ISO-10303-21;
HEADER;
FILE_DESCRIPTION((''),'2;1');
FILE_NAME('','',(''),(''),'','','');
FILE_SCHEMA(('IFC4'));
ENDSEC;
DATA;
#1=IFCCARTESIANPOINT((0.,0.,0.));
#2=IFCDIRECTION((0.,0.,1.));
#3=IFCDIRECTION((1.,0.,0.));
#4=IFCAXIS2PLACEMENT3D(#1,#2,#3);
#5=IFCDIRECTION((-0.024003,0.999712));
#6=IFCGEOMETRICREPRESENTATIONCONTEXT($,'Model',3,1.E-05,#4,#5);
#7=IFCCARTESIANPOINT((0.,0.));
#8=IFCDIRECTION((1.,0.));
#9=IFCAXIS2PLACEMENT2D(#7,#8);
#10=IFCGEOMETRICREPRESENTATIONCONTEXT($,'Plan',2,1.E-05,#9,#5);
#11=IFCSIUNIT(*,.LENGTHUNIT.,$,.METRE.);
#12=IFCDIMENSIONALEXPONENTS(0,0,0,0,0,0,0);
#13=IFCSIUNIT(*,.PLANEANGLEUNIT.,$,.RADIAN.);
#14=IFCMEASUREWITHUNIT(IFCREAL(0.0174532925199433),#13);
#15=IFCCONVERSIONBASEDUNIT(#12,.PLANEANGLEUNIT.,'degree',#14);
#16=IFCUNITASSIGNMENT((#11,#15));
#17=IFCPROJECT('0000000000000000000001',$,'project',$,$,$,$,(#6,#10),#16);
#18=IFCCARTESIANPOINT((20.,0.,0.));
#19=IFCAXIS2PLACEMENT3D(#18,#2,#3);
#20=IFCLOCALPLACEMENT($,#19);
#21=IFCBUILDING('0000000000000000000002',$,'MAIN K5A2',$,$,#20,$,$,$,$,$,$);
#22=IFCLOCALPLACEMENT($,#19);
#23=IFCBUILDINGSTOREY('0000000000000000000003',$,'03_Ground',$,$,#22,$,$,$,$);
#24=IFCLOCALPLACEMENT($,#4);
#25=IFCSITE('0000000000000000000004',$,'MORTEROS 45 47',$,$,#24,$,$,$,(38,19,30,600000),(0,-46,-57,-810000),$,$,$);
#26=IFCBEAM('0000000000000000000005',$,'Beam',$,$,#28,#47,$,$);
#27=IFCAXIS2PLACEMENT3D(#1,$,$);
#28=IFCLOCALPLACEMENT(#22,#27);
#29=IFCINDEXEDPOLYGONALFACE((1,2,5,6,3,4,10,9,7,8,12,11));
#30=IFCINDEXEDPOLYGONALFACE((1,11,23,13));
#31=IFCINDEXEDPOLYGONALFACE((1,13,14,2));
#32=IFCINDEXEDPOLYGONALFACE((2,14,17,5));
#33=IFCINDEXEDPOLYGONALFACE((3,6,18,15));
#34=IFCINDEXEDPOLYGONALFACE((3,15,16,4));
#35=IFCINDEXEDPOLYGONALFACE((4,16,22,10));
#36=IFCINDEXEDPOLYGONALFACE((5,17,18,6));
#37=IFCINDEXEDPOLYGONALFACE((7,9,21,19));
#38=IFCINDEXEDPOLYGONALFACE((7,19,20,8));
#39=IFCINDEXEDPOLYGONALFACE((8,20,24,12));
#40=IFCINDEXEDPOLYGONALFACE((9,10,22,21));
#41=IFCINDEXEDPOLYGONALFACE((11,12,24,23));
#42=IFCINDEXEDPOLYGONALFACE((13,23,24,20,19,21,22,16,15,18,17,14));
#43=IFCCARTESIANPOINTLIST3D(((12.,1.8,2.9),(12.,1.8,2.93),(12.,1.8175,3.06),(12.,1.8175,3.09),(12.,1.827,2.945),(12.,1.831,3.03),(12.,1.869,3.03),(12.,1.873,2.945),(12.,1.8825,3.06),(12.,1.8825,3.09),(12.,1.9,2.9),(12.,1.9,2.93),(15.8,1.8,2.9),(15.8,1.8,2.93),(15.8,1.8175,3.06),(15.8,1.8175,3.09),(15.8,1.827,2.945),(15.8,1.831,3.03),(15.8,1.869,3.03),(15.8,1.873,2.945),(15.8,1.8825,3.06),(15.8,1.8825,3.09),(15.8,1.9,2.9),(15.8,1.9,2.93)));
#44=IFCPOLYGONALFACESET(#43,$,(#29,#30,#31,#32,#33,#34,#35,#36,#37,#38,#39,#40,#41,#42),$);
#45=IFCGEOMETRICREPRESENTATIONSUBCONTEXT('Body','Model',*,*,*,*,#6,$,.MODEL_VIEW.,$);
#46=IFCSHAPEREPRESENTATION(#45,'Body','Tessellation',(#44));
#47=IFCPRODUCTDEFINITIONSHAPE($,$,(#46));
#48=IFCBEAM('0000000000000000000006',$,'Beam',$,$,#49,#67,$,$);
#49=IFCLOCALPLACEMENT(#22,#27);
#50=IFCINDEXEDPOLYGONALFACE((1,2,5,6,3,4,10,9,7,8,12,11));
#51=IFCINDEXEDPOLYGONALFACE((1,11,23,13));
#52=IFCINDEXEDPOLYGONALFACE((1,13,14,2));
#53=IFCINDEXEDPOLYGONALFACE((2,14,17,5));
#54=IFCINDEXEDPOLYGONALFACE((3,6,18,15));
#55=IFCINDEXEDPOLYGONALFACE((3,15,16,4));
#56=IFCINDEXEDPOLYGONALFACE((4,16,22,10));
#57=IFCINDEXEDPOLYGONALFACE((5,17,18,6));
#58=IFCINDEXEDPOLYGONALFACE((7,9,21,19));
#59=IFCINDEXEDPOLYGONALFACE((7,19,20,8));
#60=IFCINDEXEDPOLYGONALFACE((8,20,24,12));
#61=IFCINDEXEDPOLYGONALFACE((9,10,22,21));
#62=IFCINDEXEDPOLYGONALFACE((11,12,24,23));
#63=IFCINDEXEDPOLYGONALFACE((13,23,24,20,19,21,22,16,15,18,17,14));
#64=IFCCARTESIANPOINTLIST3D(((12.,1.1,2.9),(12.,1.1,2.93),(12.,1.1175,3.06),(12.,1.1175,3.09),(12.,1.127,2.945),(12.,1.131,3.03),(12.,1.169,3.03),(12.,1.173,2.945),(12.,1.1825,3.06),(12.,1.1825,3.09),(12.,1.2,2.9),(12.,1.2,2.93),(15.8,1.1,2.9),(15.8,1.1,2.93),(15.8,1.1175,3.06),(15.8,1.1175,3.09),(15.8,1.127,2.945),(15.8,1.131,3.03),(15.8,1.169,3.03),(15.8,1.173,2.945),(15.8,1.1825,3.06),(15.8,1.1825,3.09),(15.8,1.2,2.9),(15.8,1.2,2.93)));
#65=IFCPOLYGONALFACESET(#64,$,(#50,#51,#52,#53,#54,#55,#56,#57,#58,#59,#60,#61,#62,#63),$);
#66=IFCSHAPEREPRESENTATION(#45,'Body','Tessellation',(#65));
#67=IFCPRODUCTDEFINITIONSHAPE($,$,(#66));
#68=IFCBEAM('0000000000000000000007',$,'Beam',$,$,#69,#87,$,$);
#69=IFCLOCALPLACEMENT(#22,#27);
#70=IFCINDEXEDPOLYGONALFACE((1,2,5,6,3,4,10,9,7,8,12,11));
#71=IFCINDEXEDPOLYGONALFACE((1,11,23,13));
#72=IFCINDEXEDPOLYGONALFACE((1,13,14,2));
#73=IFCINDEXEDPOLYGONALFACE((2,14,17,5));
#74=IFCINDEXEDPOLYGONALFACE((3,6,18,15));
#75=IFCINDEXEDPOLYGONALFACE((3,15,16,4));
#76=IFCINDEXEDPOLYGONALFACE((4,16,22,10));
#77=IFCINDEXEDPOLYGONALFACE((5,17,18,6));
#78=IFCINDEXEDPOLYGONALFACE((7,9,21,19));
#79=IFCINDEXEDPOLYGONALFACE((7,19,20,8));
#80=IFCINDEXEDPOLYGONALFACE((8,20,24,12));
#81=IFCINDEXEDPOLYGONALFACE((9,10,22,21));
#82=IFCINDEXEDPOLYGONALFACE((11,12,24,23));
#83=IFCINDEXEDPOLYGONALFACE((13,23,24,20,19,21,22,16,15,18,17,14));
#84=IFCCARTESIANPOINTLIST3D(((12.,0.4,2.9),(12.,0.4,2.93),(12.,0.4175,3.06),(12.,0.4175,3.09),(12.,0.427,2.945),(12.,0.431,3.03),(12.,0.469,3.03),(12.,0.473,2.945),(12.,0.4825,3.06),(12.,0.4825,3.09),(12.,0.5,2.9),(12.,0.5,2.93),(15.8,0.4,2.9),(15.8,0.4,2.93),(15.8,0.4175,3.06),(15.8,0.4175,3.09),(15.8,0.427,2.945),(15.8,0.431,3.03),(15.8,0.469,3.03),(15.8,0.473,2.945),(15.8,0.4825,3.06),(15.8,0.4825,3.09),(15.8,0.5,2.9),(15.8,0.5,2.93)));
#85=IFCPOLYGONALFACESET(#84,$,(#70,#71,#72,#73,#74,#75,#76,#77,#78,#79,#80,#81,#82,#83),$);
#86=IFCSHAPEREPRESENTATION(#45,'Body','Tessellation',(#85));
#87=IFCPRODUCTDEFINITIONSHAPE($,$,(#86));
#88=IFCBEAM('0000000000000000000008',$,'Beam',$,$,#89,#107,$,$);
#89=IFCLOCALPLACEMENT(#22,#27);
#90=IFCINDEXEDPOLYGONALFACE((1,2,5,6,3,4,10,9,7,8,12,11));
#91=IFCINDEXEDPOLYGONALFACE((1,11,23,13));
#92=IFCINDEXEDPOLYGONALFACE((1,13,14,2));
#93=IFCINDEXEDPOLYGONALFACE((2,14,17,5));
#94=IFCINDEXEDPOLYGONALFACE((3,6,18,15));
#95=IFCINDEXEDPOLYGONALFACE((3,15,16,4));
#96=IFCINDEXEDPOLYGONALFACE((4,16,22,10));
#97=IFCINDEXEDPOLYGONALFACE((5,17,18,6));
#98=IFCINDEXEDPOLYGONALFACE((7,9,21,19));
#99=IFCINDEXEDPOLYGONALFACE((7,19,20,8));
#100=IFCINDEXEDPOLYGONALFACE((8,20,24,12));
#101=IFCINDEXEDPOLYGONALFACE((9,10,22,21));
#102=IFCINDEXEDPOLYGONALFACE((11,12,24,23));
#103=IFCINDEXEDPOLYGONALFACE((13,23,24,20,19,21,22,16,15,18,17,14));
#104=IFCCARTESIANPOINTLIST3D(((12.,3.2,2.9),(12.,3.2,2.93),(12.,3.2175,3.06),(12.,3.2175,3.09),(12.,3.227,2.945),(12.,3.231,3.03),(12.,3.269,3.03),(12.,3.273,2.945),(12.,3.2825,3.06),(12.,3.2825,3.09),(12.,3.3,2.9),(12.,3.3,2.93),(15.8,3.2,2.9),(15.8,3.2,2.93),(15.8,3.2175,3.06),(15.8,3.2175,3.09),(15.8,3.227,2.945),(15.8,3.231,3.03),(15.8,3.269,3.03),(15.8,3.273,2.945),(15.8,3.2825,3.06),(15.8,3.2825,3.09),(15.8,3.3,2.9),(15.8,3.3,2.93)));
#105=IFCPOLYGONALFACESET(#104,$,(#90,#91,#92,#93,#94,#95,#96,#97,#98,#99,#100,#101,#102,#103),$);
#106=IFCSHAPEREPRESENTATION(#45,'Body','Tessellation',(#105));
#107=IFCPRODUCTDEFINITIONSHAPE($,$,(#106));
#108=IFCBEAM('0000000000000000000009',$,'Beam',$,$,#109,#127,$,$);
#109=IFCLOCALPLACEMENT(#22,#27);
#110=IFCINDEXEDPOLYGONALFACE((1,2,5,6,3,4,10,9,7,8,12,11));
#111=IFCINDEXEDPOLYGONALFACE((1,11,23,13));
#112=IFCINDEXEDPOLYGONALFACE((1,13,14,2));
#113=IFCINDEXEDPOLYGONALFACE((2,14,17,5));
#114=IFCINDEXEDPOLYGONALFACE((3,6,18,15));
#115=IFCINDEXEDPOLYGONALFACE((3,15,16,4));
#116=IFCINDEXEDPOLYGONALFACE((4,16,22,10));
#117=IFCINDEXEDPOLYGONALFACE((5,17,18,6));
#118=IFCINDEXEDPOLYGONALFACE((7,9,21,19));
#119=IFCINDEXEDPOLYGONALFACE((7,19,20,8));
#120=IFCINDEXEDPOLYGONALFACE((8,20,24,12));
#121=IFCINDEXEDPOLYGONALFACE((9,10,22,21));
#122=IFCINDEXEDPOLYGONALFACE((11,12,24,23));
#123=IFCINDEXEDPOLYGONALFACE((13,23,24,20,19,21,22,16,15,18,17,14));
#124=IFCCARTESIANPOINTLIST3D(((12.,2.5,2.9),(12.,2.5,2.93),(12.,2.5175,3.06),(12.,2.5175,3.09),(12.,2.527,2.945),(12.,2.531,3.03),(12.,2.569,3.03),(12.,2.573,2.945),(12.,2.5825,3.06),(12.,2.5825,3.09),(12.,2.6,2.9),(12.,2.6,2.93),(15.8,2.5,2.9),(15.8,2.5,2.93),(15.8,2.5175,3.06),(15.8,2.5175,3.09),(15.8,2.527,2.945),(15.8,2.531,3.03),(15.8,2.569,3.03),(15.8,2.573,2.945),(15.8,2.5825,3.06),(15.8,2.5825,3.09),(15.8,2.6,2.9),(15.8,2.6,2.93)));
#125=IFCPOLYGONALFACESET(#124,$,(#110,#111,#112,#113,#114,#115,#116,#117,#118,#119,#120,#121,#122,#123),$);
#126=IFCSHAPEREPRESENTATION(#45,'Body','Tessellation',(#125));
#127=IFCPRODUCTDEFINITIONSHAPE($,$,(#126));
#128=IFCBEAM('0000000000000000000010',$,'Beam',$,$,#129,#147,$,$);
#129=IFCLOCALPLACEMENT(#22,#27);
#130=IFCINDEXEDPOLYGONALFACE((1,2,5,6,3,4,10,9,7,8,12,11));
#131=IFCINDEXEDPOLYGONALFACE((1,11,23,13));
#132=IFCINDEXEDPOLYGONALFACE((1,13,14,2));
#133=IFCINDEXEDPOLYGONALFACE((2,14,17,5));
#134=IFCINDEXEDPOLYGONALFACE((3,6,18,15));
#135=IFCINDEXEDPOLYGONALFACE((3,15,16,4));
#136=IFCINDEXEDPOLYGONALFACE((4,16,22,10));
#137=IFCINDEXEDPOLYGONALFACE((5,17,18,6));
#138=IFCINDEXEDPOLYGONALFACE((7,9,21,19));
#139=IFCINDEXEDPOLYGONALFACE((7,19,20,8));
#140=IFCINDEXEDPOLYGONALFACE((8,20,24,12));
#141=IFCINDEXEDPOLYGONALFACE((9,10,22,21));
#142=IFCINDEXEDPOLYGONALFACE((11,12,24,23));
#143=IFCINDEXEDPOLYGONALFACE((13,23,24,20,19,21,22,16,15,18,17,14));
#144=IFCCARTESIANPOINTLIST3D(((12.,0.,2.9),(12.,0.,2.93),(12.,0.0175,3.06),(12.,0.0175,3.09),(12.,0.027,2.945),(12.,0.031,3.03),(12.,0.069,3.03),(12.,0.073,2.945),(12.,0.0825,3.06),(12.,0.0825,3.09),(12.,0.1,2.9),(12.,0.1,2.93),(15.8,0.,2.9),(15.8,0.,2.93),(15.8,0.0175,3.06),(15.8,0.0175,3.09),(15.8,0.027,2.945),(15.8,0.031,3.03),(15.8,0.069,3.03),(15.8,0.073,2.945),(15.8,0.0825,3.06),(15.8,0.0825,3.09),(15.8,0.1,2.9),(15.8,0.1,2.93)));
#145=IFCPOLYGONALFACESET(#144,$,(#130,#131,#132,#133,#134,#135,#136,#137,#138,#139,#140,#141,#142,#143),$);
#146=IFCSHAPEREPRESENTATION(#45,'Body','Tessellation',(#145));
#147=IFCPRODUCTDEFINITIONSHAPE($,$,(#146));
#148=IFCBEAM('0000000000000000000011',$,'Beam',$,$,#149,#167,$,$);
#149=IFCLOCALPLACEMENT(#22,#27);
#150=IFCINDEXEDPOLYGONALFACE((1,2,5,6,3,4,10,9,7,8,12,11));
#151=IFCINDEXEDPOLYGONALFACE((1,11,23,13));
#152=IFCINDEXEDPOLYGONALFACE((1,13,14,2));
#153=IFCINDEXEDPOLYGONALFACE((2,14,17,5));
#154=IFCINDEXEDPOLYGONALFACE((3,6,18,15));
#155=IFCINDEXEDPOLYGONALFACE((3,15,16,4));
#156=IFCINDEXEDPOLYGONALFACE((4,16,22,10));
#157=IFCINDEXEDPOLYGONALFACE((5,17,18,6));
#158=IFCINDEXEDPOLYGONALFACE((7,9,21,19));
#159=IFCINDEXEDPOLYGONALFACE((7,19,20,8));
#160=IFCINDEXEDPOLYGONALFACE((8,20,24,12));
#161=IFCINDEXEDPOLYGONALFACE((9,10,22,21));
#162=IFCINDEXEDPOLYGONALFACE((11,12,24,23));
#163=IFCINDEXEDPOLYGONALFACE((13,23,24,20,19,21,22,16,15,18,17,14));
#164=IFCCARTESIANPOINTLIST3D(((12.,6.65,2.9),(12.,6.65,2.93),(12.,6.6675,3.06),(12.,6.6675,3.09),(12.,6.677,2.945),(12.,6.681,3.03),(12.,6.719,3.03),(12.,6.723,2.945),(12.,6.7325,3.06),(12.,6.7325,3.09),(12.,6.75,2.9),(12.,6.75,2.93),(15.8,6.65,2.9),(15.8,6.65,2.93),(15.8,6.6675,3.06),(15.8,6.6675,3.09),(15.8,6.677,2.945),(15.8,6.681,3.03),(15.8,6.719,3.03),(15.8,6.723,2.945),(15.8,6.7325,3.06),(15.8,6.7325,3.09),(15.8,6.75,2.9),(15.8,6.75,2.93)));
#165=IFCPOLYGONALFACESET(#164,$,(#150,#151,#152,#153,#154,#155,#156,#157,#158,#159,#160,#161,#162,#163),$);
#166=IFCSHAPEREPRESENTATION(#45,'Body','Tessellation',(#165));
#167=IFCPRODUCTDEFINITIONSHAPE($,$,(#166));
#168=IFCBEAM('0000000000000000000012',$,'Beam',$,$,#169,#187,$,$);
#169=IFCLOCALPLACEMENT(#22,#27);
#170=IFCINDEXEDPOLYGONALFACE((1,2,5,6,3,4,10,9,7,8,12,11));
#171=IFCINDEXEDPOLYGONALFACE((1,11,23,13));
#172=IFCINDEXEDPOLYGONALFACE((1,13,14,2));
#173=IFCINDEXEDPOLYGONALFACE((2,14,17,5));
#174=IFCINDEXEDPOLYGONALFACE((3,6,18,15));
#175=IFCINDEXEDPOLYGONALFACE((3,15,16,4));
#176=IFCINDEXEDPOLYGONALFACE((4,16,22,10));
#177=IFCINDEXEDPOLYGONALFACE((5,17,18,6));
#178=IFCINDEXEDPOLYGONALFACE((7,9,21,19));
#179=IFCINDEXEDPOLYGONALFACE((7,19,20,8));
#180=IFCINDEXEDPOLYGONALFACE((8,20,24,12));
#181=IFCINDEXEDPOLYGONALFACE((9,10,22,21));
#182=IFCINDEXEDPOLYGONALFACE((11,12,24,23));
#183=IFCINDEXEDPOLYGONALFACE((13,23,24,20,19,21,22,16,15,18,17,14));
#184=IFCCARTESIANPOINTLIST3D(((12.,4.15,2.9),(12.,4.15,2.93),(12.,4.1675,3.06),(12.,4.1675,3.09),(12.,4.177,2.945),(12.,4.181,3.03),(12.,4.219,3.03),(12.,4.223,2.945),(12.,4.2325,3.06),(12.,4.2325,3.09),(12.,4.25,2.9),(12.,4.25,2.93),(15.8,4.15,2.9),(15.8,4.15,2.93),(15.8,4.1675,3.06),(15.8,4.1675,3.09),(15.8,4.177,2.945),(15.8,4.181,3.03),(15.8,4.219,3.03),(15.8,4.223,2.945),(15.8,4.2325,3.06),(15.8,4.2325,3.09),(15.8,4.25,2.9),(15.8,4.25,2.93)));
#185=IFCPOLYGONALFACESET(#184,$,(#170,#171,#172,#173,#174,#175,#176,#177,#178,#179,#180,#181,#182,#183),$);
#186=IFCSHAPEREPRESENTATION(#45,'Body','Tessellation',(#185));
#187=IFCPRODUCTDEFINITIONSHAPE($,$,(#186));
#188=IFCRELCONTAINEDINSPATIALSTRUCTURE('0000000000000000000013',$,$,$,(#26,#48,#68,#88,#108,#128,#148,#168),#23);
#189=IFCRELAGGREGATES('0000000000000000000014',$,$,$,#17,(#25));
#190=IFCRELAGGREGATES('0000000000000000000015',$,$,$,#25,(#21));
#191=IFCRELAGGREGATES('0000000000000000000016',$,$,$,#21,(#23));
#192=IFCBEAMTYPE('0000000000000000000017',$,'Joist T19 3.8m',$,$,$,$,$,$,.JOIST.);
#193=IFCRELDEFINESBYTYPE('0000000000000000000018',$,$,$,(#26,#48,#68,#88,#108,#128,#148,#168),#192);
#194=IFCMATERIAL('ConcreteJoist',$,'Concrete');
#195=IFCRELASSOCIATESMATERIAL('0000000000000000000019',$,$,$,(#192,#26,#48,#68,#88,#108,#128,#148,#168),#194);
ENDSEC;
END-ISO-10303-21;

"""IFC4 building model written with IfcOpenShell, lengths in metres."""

from ifc_helpers import new_model, entity, si_unit, converted_unit, direction, frame, origin_with_axes, origin_2d_with_axis, place, context, subcontext, project, spatial, indexed_curve, outline, extrude, material, material_profile, profile_set, profile_usage, type_object, element, save


model = new_model("IFC4")

# Units and contexts
model_context = context("Model", 3, precision=1e-05, world=origin_with_axes(), true_north=direction((-0.024003, 0.999712)))
plan_context = context("Plan", 2, precision=1e-05, world=origin_2d_with_axis(), true_north=direction((-0.024003, 0.999712)))
body_context_1 = subcontext(model_context, "Body", "Model", "MODEL_VIEW")
ifc_project = project(units=[si_unit("LENGTHUNIT", "METRE"), converted_unit("PLANEANGLEUNIT", "degree", entity("IfcReal", 0.0174532925199433), si_unit("PLANEANGLEUNIT", "RADIAN"), dimensions=[0, 0, 0, 0, 0, 0, 0])], contexts=[model_context, plan_context])

# Site, building, storey
site_placement = place(None, origin_with_axes())
site = spatial("IfcSite", under=ifc_project, at=site_placement, Name="MORTEROS 45 47", RefLatitude=(38, 19, 30, 600000), RefLongitude=(0, -46, -57, -810000))
building_placement = place(None, frame((20.0, 0.0, 0.0), z_axis=(0.0, 0.0, 1.0), x_axis=(1.0, 0.0, 0.0)))
building = spatial("IfcBuilding", under=site, at=building_placement, Name="MAIN K5A2")
storey_placement = place(None, frame((20.0, 0.0, 0.0), z_axis=(0.0, 0.0, 1.0), x_axis=(1.0, 0.0, 0.0)))
storey = spatial("IfcBuildingStorey", under=building, at=storey_placement, Name="03_Ground")

# Beams
ifc_material = material(Name="ConcreteJoist", Category="Concrete")
ifc_material_profile_1 = material_profile(ifc_material, outline(indexed_curve([(0.019, 0.13), (0.023, 0.045), (0.05, 0.03), (0.05, 0.0), (-0.05, 0.0), (-0.05, 0.03), (-0.023, 0.045), (-0.019, 0.13), (-0.0325, 0.16), (-0.0325, 0.19), (0.0325, 0.19), (0.0325, 0.16), (0.019, 0.13)])))
ifc_profile_set_1 = profile_set([ifc_material_profile_1], Name="JoistMaterialProfileSet")
ifc_material_profile_2 = material_profile(ifc_material, outline(indexed_curve([(0.019, 0.13), (0.023, 0.045), (0.05, 0.03), (0.05, 0.0), (-0.05, 0.0), (-0.05, 0.03), (-0.023, 0.045), (-0.019, 0.13), (-0.0325, 0.16), (-0.0325, 0.19), (0.0325, 0.19), (0.0325, 0.16), (0.019, 0.13)])))
ifc_profile_set_2 = profile_set([ifc_material_profile_2], Name="JoistMaterialProfileSet")
beam_type_1 = type_object("IfcBeamType", Name="Joist T19 3.8m", PredefinedType="JOIST", material=ifc_profile_set_2)
ifc_profile_usage_1 = profile_usage(ifc_profile_set_1)
beam_1_placement = place(None, frame((32.0, 1.85, 2.9), z_axis=(1.0, 0.0, 0.0), x_axis=(0.0, 1.0, 0.0)))
element("IfcBeam", 1, at=beam_1_placement, inside=storey, type_object=beam_type_1, material=ifc_profile_usage_1, Name="Beam", context=body_context_1, shape_type="SweptSolid", body=[
    extrude(outline(indexed_curve([(0.019, 0.13), (0.023, 0.045), (0.05, 0.03), (0.05, 0.0), (-0.05, 0.0), (-0.05, 0.03), (-0.023, 0.045), (-0.019, 0.13), (-0.0325, 0.16), (-0.0325, 0.19), (0.0325, 0.19), (0.0325, 0.16), (0.019, 0.13)])), origin_with_axes(), (0.0, 0.0, 1.0), 3.8),
])
ifc_profile_usage_2 = profile_usage(ifc_profile_set_1)
beam_2_placement = place(None, frame((32.0, 1.15, 2.9), z_axis=(1.0, 0.0, 0.0), x_axis=(0.0, 1.0, 0.0)))
element("IfcBeam", 2, at=beam_2_placement, inside=storey, type_object=beam_type_1, material=ifc_profile_usage_2, Name="Beam", context=body_context_1, shape_type="SweptSolid", body=[
    extrude(outline(indexed_curve([(0.019, 0.13), (0.023, 0.045), (0.05, 0.03), (0.05, 0.0), (-0.05, 0.0), (-0.05, 0.03), (-0.023, 0.045), (-0.019, 0.13), (-0.0325, 0.16), (-0.0325, 0.19), (0.0325, 0.19), (0.0325, 0.16), (0.019, 0.13)])), origin_with_axes(), (0.0, 0.0, 1.0), 3.8),
])
ifc_profile_usage_3 = profile_usage(ifc_profile_set_1)
beam_3_placement = place(None, frame((32.0, 0.45, 2.9), z_axis=(1.0, 0.0, 0.0), x_axis=(0.0, 1.0, 0.0)))
element("IfcBeam", 3, at=beam_3_placement, inside=storey, type_object=beam_type_1, material=ifc_profile_usage_3, Name="Beam", context=body_context_1, shape_type="SweptSolid", body=[
    extrude(outline(indexed_curve([(0.019, 0.13), (0.023, 0.045), (0.05, 0.03), (0.05, 0.0), (-0.05, 0.0), (-0.05, 0.03), (-0.023, 0.045), (-0.019, 0.13), (-0.0325, 0.16), (-0.0325, 0.19), (0.0325, 0.19), (0.0325, 0.16), (0.019, 0.13)])), origin_with_axes(), (0.0, 0.0, 1.0), 3.8),
])
ifc_profile_usage_4 = profile_usage(ifc_profile_set_1)
beam_4_placement = place(None, frame((32.0, 3.25, 2.9), z_axis=(1.0, 0.0, 0.0), x_axis=(0.0, 1.0, 0.0)))
element("IfcBeam", 4, at=beam_4_placement, inside=storey, type_object=beam_type_1, material=ifc_profile_usage_4, Name="Beam", context=body_context_1, shape_type="SweptSolid", body=[
    extrude(outline(indexed_curve([(0.019, 0.13), (0.023, 0.045), (0.05, 0.03), (0.05, 0.0), (-0.05, 0.0), (-0.05, 0.03), (-0.023, 0.045), (-0.019, 0.13), (-0.0325, 0.16), (-0.0325, 0.19), (0.0325, 0.19), (0.0325, 0.16), (0.019, 0.13)])), origin_with_axes(), (0.0, 0.0, 1.0), 3.8),
])
ifc_profile_usage_5 = profile_usage(ifc_profile_set_1)
beam_5_placement = place(None, frame((32.0, 2.55, 2.9), z_axis=(1.0, 0.0, 0.0), x_axis=(0.0, 1.0, 0.0)))
element("IfcBeam", 5, at=beam_5_placement, inside=storey, type_object=beam_type_1, material=ifc_profile_usage_5, Name="Beam", context=body_context_1, shape_type="SweptSolid", body=[
    extrude(outline(indexed_curve([(0.019, 0.13), (0.023, 0.045), (0.05, 0.03), (0.05, 0.0), (-0.05, 0.0), (-0.05, 0.03), (-0.023, 0.045), (-0.019, 0.13), (-0.0325, 0.16), (-0.0325, 0.19), (0.0325, 0.19), (0.0325, 0.16), (0.019, 0.13)])), origin_with_axes(), (0.0, 0.0, 1.0), 3.8),
])
ifc_profile_usage_6 = profile_usage(ifc_profile_set_1)
beam_6_placement = place(None, frame((32.0, 0.05, 2.9), z_axis=(1.0, 0.0, 0.0), x_axis=(0.0, 1.0, 0.0)))
element("IfcBeam", 6, at=beam_6_placement, inside=storey, type_object=beam_type_1, material=ifc_profile_usage_6, Name="Beam", context=body_context_1, shape_type="SweptSolid", body=[
    extrude(outline(indexed_curve([(0.019, 0.13), (0.023, 0.045), (0.05, 0.03), (0.05, 0.0), (-0.05, 0.0), (-0.05, 0.03), (-0.023, 0.045), (-0.019, 0.13), (-0.0325, 0.16), (-0.0325, 0.19), (0.0325, 0.19), (0.0325, 0.16), (0.019, 0.13)])), origin_with_axes(), (0.0, 0.0, 1.0), 3.8),
])
ifc_profile_usage_7 = profile_usage(ifc_profile_set_1)
beam_7_placement = place(None, frame((32.0, 6.7, 2.9), z_axis=(1.0, 0.0, 0.0), x_axis=(0.0, 1.0, 0.0)))
element("IfcBeam", 7, at=beam_7_placement, inside=storey, type_object=beam_type_1, material=ifc_profile_usage_7, Name="Beam", context=body_context_1, shape_type="SweptSolid", body=[
    extrude(outline(indexed_curve([(0.019, 0.13), (0.023, 0.045), (0.05, 0.03), (0.05, 0.0), (-0.05, 0.0), (-0.05, 0.03), (-0.023, 0.045), (-0.019, 0.13), (-0.0325, 0.16), (-0.0325, 0.19), (0.0325, 0.19), (0.0325, 0.16), (0.019, 0.13)])), origin_with_axes(), (0.0, 0.0, 1.0), 3.8),
])
ifc_profile_usage_8 = profile_usage(ifc_profile_set_1)
beam_8_placement = place(None, frame((32.0, 4.2, 2.9), z_axis=(1.0, 0.0, 0.0), x_axis=(0.0, 1.0, 0.0)))
element("IfcBeam", 8, at=beam_8_placement, inside=storey, type_object=beam_type_1, material=ifc_profile_usage_8, Name="Beam", context=body_context_1, shape_type="SweptSolid", body=[
    extrude(outline(indexed_curve([(0.019, 0.13), (0.023, 0.045), (0.05, 0.03), (0.05, 0.0), (-0.05, 0.0), (-0.05, 0.03), (-0.023, 0.045), (-0.019, 0.13), (-0.0325, 0.16), (-0.0325, 0.19), (0.0325, 0.19), (0.0325, 0.16), (0.019, 0.13)])), origin_with_axes(), (0.0, 0.0, 1.0), 3.8),
])

save(model, "model.ifc")
